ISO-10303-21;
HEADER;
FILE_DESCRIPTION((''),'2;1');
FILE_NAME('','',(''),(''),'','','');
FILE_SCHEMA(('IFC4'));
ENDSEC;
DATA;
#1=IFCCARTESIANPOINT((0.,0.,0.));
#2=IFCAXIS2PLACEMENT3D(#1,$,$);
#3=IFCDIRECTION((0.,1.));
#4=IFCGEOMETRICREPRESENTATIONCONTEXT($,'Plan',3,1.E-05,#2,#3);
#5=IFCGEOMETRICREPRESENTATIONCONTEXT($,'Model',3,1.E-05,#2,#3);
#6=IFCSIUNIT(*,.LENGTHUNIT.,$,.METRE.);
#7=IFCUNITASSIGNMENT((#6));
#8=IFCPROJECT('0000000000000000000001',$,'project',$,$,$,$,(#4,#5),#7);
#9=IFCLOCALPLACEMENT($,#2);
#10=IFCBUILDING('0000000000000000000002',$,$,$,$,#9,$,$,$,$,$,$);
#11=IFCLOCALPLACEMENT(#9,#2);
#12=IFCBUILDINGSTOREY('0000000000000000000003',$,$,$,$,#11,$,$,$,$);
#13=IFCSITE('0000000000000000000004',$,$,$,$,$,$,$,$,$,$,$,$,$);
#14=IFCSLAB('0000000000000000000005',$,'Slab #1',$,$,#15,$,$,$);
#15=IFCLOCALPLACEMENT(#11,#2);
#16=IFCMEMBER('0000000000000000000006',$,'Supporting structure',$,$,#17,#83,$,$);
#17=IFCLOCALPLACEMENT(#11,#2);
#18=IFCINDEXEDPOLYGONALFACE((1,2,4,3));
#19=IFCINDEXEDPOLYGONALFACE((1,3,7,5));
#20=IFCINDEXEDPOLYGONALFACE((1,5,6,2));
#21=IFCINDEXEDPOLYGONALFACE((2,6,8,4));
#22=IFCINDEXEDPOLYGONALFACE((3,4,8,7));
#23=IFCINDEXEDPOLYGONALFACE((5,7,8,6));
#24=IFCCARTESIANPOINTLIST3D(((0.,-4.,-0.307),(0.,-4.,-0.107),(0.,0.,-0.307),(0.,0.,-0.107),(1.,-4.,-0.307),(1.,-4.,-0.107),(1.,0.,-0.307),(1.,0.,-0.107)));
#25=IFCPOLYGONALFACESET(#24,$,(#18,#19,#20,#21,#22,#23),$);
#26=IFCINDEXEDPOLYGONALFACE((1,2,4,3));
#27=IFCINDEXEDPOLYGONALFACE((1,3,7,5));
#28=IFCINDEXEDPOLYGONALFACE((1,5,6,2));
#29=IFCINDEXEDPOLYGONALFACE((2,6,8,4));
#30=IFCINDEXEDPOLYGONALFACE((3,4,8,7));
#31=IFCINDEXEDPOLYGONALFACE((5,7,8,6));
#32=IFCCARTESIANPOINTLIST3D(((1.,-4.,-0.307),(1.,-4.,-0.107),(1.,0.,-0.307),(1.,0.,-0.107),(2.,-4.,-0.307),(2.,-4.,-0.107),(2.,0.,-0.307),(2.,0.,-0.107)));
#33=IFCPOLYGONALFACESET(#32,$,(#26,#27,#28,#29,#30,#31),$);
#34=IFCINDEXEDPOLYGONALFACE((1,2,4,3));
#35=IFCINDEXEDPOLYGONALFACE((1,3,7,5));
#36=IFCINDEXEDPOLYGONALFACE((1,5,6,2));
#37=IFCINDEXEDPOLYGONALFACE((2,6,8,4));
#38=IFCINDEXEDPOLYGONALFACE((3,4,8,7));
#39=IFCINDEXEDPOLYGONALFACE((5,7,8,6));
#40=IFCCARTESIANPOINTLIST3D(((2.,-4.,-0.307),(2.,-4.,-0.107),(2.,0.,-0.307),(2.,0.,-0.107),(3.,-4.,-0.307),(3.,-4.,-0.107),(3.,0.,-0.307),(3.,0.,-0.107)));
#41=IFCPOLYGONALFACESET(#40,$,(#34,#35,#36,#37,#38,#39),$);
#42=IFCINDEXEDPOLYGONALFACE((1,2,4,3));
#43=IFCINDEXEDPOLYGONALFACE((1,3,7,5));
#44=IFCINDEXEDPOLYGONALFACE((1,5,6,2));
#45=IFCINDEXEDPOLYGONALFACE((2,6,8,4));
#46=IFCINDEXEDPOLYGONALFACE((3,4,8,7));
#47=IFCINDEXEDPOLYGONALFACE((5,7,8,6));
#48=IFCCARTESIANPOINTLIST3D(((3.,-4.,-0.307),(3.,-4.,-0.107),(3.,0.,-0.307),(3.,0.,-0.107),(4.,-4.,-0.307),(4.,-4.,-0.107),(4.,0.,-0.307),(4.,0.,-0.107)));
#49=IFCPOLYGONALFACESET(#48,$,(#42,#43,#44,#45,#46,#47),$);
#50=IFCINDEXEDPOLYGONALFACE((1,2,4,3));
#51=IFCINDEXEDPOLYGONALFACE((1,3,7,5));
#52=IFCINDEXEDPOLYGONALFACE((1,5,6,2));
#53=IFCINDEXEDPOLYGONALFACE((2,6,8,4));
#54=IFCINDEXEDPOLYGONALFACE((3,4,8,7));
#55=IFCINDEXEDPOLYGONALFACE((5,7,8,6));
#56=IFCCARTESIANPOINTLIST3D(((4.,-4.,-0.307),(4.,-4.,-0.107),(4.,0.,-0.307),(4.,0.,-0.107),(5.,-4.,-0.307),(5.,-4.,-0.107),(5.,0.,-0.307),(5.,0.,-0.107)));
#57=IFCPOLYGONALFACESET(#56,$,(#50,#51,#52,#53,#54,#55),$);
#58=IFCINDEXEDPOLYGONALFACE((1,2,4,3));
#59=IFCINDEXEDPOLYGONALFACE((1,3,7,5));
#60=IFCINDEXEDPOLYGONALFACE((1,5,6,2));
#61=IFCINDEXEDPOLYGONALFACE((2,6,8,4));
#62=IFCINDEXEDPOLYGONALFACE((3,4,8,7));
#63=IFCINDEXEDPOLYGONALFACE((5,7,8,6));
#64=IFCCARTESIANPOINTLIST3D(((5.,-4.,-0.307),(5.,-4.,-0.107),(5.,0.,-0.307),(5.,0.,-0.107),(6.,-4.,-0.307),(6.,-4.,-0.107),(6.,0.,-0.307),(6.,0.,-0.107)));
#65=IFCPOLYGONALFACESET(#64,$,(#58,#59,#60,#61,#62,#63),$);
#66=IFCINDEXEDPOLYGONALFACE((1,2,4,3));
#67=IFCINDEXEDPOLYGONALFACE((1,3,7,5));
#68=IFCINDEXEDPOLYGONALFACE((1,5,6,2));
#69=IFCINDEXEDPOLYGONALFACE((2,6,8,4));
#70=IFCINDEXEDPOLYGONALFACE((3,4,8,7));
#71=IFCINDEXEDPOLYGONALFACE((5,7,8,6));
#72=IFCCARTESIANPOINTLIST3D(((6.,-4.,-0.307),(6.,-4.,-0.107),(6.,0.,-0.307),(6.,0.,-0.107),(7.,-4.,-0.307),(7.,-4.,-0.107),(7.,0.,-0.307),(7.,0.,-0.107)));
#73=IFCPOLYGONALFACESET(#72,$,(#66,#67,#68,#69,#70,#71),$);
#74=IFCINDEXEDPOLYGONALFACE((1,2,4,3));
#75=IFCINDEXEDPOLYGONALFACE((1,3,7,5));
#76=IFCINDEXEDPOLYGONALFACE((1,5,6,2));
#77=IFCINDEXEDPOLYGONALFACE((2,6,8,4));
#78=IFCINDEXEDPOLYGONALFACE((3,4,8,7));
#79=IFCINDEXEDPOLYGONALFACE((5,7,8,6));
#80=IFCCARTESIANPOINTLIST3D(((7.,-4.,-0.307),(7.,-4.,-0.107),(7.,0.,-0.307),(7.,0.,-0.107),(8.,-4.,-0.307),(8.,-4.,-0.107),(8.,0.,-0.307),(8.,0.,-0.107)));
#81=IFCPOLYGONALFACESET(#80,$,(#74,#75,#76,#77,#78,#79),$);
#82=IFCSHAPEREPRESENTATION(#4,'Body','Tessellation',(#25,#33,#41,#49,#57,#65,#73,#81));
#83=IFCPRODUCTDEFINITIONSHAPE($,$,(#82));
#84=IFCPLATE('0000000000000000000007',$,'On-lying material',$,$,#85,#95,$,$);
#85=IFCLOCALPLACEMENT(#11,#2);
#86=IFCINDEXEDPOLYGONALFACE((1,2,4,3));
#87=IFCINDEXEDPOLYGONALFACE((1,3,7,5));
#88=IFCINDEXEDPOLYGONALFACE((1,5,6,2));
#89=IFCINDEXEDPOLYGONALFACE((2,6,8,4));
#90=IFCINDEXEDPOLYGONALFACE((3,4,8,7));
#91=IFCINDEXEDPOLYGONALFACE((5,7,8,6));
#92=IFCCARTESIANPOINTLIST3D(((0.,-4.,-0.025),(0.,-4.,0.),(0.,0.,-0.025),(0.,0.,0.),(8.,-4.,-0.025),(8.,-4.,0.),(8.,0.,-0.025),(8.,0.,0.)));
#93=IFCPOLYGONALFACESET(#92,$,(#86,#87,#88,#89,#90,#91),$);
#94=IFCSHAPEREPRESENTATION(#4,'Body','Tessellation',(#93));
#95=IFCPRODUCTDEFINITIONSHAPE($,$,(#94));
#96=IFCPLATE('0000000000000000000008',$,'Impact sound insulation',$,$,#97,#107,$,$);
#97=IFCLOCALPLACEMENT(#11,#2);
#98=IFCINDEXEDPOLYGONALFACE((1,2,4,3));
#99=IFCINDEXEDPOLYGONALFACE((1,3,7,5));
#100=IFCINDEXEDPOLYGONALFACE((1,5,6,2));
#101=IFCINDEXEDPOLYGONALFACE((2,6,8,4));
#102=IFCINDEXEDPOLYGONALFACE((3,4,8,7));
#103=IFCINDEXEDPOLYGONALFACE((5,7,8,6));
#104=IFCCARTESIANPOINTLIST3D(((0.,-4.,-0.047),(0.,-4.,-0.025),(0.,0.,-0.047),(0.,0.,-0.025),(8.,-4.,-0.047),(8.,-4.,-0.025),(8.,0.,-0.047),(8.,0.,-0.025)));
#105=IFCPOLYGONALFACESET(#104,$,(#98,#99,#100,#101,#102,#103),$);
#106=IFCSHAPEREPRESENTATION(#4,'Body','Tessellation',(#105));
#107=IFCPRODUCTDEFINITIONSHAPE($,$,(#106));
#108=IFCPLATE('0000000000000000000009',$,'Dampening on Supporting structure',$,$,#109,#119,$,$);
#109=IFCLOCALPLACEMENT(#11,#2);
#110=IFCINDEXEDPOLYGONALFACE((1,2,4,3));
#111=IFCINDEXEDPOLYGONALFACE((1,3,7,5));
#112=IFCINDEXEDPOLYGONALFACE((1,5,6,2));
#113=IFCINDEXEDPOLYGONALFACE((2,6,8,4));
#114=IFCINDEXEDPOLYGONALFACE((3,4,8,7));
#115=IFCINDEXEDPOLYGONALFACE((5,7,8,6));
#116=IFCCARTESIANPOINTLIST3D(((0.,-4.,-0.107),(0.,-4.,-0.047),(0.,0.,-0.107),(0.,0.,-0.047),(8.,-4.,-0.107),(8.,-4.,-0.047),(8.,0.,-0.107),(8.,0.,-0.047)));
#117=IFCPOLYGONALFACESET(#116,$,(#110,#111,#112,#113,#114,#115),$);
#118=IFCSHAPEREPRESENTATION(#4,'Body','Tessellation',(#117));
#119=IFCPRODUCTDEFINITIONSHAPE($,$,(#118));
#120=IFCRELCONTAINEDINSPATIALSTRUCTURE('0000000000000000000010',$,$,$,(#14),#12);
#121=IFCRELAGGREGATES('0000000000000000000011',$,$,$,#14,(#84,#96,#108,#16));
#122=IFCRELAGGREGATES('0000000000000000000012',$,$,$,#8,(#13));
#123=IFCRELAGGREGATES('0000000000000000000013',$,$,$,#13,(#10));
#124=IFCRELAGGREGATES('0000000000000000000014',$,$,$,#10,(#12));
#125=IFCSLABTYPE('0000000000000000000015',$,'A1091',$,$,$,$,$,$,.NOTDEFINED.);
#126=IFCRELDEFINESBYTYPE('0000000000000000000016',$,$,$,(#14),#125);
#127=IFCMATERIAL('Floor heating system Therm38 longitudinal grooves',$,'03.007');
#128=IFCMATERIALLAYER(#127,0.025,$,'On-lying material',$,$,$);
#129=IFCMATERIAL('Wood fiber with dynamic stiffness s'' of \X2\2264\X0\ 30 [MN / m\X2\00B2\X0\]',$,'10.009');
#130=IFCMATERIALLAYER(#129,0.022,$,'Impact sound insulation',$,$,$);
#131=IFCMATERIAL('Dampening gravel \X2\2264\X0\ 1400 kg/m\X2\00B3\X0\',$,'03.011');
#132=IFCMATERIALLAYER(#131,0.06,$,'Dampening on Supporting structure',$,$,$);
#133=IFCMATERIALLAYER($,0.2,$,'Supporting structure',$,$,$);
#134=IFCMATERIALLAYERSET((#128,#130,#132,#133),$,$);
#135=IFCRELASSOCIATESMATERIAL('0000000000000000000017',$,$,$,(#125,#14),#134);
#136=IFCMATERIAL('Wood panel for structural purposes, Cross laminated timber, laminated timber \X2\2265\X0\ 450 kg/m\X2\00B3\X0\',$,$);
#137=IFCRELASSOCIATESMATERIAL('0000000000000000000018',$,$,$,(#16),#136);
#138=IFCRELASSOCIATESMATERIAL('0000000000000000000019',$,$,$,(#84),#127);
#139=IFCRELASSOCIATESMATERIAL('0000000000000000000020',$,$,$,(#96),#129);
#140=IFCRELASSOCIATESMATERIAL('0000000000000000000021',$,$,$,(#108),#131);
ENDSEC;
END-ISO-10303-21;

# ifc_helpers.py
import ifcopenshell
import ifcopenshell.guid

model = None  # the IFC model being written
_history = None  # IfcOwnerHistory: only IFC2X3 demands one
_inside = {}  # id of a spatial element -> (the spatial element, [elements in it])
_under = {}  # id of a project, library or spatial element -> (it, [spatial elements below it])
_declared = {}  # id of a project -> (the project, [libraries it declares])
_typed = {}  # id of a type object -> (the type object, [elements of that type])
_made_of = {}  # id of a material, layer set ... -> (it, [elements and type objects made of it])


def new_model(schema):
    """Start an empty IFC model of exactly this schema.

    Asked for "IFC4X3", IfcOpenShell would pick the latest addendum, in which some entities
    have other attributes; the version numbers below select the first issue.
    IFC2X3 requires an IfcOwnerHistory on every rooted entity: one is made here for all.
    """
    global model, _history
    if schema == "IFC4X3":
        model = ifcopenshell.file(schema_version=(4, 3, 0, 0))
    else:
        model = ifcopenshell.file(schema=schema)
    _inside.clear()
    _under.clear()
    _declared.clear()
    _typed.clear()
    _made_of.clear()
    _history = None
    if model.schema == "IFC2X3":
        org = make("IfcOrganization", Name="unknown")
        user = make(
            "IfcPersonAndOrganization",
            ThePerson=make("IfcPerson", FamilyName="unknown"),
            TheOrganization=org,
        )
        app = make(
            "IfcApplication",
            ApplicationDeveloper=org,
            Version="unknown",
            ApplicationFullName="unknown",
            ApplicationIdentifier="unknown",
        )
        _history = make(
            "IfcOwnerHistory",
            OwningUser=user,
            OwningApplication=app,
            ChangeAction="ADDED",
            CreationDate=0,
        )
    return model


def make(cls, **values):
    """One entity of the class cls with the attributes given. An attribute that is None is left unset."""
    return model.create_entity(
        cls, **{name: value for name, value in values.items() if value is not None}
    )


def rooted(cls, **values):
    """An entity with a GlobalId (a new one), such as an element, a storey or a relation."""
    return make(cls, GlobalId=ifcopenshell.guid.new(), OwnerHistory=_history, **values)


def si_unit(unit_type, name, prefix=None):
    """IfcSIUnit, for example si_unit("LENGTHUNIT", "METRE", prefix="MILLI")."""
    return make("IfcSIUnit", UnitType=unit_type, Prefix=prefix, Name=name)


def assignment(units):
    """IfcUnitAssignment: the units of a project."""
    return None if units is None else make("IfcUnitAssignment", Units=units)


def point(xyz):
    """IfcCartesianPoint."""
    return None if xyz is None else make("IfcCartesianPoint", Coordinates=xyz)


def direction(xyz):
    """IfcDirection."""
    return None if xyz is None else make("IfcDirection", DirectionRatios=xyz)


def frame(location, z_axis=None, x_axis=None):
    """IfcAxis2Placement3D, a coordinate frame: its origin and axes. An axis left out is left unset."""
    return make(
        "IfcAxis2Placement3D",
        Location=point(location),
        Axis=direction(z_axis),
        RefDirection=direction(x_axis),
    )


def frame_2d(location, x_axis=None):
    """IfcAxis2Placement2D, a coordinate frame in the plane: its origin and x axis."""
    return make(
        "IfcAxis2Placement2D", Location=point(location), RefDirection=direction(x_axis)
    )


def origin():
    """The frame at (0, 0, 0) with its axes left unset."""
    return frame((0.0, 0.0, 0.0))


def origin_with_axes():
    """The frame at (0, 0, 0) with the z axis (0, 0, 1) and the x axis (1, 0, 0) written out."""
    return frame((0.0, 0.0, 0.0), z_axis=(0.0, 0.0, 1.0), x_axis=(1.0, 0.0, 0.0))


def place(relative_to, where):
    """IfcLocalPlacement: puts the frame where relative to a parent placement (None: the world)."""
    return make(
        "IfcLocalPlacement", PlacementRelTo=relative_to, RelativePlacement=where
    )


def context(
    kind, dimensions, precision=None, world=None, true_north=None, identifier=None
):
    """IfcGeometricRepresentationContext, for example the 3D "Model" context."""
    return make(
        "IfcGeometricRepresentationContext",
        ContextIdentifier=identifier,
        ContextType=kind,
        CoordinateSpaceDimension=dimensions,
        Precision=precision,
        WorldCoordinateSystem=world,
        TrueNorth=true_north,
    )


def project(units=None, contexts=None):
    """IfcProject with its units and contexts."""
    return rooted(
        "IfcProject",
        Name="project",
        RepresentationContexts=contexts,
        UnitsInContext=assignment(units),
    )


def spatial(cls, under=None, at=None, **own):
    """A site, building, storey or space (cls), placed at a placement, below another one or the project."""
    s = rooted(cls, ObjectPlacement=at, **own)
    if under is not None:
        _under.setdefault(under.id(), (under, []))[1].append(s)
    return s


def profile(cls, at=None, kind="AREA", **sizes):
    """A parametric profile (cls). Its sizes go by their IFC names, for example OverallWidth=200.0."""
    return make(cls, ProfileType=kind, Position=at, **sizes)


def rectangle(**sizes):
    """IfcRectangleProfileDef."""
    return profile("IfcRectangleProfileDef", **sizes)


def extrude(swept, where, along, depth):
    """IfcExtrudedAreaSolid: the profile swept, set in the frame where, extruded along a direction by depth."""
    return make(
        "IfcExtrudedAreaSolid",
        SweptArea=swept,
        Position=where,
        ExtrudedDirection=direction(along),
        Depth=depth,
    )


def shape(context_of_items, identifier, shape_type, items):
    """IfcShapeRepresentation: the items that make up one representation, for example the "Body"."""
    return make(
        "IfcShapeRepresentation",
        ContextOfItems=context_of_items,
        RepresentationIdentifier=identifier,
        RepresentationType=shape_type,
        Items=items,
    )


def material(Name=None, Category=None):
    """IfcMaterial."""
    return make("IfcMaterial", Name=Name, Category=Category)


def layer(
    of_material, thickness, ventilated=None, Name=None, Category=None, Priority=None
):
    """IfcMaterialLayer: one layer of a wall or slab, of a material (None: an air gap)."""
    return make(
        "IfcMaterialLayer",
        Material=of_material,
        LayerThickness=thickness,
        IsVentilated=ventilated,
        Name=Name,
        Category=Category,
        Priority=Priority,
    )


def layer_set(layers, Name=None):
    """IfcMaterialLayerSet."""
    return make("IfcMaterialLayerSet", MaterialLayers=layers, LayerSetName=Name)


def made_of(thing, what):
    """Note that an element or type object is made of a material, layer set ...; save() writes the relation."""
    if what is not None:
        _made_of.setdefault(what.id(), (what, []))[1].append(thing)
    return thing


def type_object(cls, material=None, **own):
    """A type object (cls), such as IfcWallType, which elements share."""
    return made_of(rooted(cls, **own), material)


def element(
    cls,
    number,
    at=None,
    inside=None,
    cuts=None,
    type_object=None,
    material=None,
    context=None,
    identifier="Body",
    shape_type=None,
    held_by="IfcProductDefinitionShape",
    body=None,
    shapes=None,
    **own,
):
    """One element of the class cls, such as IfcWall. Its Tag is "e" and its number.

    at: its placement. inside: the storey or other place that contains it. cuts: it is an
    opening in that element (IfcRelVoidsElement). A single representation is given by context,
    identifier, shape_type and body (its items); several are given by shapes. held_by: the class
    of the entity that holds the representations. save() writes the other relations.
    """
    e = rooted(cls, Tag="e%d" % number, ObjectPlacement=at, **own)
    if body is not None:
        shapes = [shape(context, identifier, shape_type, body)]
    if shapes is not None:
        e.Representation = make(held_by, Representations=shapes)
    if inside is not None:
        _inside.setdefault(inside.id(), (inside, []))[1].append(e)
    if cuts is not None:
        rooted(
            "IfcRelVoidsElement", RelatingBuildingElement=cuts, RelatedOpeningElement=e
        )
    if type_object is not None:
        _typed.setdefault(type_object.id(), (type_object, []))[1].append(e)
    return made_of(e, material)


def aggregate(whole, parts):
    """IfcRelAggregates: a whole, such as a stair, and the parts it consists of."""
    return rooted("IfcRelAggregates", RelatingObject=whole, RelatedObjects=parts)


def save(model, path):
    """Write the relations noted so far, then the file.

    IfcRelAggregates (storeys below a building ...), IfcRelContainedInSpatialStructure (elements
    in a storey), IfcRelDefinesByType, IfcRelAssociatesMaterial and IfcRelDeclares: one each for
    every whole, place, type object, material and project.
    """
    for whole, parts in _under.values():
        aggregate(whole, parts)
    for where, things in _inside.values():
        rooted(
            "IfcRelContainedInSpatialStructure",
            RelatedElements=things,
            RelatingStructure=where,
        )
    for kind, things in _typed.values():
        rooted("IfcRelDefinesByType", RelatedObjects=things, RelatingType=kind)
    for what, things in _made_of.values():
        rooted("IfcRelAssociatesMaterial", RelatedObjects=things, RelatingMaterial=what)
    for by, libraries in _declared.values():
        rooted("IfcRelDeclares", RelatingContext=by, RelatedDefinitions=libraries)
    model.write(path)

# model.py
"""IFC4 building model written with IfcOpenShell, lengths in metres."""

from ifc_helpers import new_model, si_unit, direction, frame, frame_2d, origin, origin_with_axes, place, context, project, spatial, rectangle, extrude, material, layer, layer_set, type_object, element, aggregate, save


model = new_model("IFC4")

# Units and contexts
plan_context = context("Plan", 3, precision=1e-05, world=origin(), true_north=direction((0.0, 1.0)))
model_context = context("Model", 3, precision=1e-05, world=origin(), true_north=direction((0.0, 1.0)))
ifc_project = project(units=[si_unit("LENGTHUNIT", "METRE")], contexts=[plan_context, model_context])

# Site, building, storey
site = spatial("IfcSite", under=ifc_project)
building_placement = place(None, origin())
building = spatial("IfcBuilding", under=site, at=building_placement)
storey_placement = place(building_placement, origin())
storey = spatial("IfcBuildingStorey", under=building, at=storey_placement)

# Slab, member, plates
ifc_material_1 = material(Name="Floor heating system Therm38 longitudinal grooves", Category="03.007")
ifc_layer_1 = layer(ifc_material_1, 0.025, Name="On-lying material")
ifc_material_2 = material(Name="Wood fiber with dynamic stiffness s' of ≤ 30 [MN / m²]", Category="10.009")
ifc_layer_2 = layer(ifc_material_2, 0.022, Name="Impact sound insulation")
ifc_material_3 = material(Name="Dampening gravel ≤ 1400 kg/m³", Category="03.011")
ifc_layer_3 = layer(ifc_material_3, 0.06, Name="Dampening on Supporting structure")
ifc_layer_4 = layer(None, 0.2, Name="Supporting structure")
ifc_layer_set = layer_set([ifc_layer_1, ifc_layer_2, ifc_layer_3, ifc_layer_4])
slab_type = type_object("IfcSlabType", Name="A1091", PredefinedType="NOTDEFINED", material=ifc_layer_set)
slab_placement = place(None, frame((0.0, 0.0, 0.0), z_axis=(0.0, 0.0, -1.0), x_axis=(1.0, 0.0, 0.0)))
slab = element("IfcSlab", 1, at=slab_placement, inside=storey, type_object=slab_type, material=ifc_layer_set, Name="Slab #1")
ifc_material_4 = material(Name="Wood panel for structural purposes, Cross laminated timber, laminated timber ≥ 450 kg/m³")
member_placement = place(slab_placement, origin())
member = element("IfcMember", 2, at=member_placement, material=ifc_material_4, Name="Supporting structure", context=plan_context, shape_type="SweptSolid", body=[
    extrude(rectangle(XDim=1.0, YDim=0.2, at=frame_2d((0.5, 0.1), x_axis=(1.0, 0.0))), frame((0.0, 4.0, 0.107), z_axis=(0.0, -1.0, 0.0), x_axis=(1.0, 0.0, 0.0)), (0.0, 0.0, 1.0), 4.0),
    extrude(rectangle(XDim=1.0, YDim=0.2, at=frame_2d((0.5, 0.1), x_axis=(1.0, 0.0))), frame((1.0, 4.0, 0.107), z_axis=(0.0, -1.0, 0.0), x_axis=(1.0, 0.0, 0.0)), (0.0, 0.0, 1.0), 4.0),
    extrude(rectangle(XDim=1.0, YDim=0.2, at=frame_2d((0.5, 0.1), x_axis=(1.0, 0.0))), frame((2.0, 4.0, 0.107), z_axis=(0.0, -1.0, 0.0), x_axis=(1.0, 0.0, 0.0)), (0.0, 0.0, 1.0), 4.0),
    extrude(rectangle(XDim=1.0, YDim=0.2, at=frame_2d((0.5, 0.1), x_axis=(1.0, 0.0))), frame((3.0, 4.0, 0.107), z_axis=(0.0, -1.0, 0.0), x_axis=(1.0, 0.0, 0.0)), (0.0, 0.0, 1.0), 4.0),
    extrude(rectangle(XDim=1.0, YDim=0.2, at=frame_2d((0.5, 0.1), x_axis=(1.0, 0.0))), frame((4.0, 4.0, 0.107), z_axis=(0.0, -1.0, 0.0), x_axis=(1.0, 0.0, 0.0)), (0.0, 0.0, 1.0), 4.0),
    extrude(rectangle(XDim=1.0, YDim=0.2, at=frame_2d((0.5, 0.1), x_axis=(1.0, 0.0))), frame((5.0, 4.0, 0.107), z_axis=(0.0, -1.0, 0.0), x_axis=(1.0, 0.0, 0.0)), (0.0, 0.0, 1.0), 4.0),
    extrude(rectangle(XDim=1.0, YDim=0.2, at=frame_2d((0.5, 0.1), x_axis=(1.0, 0.0))), frame((6.0, 4.0, 0.107), z_axis=(0.0, -1.0, 0.0), x_axis=(1.0, 0.0, 0.0)), (0.0, 0.0, 1.0), 4.0),
    extrude(rectangle(XDim=1.0, YDim=0.2, at=frame_2d((0.5, 0.1), x_axis=(1.0, 0.0))), frame((7.0, 4.0, 0.107), z_axis=(0.0, -1.0, 0.0), x_axis=(1.0, 0.0, 0.0)), (0.0, 0.0, 1.0), 4.0),
])
plate_1_placement = place(slab_placement, origin())
plate_1 = element("IfcPlate", 3, at=plate_1_placement, material=ifc_material_1, Name="On-lying material", context=plan_context, shape_type="SweptSolid", body=[
    extrude(rectangle(XDim=8.0, YDim=4.0, at=frame_2d((4.0, 2.0), x_axis=(1.0, 0.0))), origin_with_axes(), (0.0, 0.0, 1.0), 0.025),
])
plate_2_placement = place(slab_placement, origin())
plate_2 = element("IfcPlate", 4, at=plate_2_placement, material=ifc_material_2, Name="Impact sound insulation", context=plan_context, shape_type="SweptSolid", body=[
    extrude(rectangle(XDim=8.0, YDim=4.0, at=frame_2d((4.0, 2.0), x_axis=(1.0, 0.0))), frame((0.0, 0.0, 0.025), z_axis=(0.0, 0.0, 1.0), x_axis=(1.0, 0.0, 0.0)), (0.0, 0.0, 1.0), 0.022),
])
plate_3_placement = place(slab_placement, origin())
plate_3 = element("IfcPlate", 5, at=plate_3_placement, material=ifc_material_3, Name="Dampening on Supporting structure", context=plan_context, shape_type="SweptSolid", body=[
    extrude(rectangle(XDim=8.0, YDim=4.0, at=frame_2d((4.0, 2.0), x_axis=(1.0, 0.0))), frame((0.0, 0.0, 0.047), z_axis=(0.0, 0.0, 1.0), x_axis=(1.0, 0.0, 0.0)), (0.0, 0.0, 1.0), 0.06),
])
aggregate(slab, [plate_1, plate_2, plate_3, member])

save(model, "model.ifc")
